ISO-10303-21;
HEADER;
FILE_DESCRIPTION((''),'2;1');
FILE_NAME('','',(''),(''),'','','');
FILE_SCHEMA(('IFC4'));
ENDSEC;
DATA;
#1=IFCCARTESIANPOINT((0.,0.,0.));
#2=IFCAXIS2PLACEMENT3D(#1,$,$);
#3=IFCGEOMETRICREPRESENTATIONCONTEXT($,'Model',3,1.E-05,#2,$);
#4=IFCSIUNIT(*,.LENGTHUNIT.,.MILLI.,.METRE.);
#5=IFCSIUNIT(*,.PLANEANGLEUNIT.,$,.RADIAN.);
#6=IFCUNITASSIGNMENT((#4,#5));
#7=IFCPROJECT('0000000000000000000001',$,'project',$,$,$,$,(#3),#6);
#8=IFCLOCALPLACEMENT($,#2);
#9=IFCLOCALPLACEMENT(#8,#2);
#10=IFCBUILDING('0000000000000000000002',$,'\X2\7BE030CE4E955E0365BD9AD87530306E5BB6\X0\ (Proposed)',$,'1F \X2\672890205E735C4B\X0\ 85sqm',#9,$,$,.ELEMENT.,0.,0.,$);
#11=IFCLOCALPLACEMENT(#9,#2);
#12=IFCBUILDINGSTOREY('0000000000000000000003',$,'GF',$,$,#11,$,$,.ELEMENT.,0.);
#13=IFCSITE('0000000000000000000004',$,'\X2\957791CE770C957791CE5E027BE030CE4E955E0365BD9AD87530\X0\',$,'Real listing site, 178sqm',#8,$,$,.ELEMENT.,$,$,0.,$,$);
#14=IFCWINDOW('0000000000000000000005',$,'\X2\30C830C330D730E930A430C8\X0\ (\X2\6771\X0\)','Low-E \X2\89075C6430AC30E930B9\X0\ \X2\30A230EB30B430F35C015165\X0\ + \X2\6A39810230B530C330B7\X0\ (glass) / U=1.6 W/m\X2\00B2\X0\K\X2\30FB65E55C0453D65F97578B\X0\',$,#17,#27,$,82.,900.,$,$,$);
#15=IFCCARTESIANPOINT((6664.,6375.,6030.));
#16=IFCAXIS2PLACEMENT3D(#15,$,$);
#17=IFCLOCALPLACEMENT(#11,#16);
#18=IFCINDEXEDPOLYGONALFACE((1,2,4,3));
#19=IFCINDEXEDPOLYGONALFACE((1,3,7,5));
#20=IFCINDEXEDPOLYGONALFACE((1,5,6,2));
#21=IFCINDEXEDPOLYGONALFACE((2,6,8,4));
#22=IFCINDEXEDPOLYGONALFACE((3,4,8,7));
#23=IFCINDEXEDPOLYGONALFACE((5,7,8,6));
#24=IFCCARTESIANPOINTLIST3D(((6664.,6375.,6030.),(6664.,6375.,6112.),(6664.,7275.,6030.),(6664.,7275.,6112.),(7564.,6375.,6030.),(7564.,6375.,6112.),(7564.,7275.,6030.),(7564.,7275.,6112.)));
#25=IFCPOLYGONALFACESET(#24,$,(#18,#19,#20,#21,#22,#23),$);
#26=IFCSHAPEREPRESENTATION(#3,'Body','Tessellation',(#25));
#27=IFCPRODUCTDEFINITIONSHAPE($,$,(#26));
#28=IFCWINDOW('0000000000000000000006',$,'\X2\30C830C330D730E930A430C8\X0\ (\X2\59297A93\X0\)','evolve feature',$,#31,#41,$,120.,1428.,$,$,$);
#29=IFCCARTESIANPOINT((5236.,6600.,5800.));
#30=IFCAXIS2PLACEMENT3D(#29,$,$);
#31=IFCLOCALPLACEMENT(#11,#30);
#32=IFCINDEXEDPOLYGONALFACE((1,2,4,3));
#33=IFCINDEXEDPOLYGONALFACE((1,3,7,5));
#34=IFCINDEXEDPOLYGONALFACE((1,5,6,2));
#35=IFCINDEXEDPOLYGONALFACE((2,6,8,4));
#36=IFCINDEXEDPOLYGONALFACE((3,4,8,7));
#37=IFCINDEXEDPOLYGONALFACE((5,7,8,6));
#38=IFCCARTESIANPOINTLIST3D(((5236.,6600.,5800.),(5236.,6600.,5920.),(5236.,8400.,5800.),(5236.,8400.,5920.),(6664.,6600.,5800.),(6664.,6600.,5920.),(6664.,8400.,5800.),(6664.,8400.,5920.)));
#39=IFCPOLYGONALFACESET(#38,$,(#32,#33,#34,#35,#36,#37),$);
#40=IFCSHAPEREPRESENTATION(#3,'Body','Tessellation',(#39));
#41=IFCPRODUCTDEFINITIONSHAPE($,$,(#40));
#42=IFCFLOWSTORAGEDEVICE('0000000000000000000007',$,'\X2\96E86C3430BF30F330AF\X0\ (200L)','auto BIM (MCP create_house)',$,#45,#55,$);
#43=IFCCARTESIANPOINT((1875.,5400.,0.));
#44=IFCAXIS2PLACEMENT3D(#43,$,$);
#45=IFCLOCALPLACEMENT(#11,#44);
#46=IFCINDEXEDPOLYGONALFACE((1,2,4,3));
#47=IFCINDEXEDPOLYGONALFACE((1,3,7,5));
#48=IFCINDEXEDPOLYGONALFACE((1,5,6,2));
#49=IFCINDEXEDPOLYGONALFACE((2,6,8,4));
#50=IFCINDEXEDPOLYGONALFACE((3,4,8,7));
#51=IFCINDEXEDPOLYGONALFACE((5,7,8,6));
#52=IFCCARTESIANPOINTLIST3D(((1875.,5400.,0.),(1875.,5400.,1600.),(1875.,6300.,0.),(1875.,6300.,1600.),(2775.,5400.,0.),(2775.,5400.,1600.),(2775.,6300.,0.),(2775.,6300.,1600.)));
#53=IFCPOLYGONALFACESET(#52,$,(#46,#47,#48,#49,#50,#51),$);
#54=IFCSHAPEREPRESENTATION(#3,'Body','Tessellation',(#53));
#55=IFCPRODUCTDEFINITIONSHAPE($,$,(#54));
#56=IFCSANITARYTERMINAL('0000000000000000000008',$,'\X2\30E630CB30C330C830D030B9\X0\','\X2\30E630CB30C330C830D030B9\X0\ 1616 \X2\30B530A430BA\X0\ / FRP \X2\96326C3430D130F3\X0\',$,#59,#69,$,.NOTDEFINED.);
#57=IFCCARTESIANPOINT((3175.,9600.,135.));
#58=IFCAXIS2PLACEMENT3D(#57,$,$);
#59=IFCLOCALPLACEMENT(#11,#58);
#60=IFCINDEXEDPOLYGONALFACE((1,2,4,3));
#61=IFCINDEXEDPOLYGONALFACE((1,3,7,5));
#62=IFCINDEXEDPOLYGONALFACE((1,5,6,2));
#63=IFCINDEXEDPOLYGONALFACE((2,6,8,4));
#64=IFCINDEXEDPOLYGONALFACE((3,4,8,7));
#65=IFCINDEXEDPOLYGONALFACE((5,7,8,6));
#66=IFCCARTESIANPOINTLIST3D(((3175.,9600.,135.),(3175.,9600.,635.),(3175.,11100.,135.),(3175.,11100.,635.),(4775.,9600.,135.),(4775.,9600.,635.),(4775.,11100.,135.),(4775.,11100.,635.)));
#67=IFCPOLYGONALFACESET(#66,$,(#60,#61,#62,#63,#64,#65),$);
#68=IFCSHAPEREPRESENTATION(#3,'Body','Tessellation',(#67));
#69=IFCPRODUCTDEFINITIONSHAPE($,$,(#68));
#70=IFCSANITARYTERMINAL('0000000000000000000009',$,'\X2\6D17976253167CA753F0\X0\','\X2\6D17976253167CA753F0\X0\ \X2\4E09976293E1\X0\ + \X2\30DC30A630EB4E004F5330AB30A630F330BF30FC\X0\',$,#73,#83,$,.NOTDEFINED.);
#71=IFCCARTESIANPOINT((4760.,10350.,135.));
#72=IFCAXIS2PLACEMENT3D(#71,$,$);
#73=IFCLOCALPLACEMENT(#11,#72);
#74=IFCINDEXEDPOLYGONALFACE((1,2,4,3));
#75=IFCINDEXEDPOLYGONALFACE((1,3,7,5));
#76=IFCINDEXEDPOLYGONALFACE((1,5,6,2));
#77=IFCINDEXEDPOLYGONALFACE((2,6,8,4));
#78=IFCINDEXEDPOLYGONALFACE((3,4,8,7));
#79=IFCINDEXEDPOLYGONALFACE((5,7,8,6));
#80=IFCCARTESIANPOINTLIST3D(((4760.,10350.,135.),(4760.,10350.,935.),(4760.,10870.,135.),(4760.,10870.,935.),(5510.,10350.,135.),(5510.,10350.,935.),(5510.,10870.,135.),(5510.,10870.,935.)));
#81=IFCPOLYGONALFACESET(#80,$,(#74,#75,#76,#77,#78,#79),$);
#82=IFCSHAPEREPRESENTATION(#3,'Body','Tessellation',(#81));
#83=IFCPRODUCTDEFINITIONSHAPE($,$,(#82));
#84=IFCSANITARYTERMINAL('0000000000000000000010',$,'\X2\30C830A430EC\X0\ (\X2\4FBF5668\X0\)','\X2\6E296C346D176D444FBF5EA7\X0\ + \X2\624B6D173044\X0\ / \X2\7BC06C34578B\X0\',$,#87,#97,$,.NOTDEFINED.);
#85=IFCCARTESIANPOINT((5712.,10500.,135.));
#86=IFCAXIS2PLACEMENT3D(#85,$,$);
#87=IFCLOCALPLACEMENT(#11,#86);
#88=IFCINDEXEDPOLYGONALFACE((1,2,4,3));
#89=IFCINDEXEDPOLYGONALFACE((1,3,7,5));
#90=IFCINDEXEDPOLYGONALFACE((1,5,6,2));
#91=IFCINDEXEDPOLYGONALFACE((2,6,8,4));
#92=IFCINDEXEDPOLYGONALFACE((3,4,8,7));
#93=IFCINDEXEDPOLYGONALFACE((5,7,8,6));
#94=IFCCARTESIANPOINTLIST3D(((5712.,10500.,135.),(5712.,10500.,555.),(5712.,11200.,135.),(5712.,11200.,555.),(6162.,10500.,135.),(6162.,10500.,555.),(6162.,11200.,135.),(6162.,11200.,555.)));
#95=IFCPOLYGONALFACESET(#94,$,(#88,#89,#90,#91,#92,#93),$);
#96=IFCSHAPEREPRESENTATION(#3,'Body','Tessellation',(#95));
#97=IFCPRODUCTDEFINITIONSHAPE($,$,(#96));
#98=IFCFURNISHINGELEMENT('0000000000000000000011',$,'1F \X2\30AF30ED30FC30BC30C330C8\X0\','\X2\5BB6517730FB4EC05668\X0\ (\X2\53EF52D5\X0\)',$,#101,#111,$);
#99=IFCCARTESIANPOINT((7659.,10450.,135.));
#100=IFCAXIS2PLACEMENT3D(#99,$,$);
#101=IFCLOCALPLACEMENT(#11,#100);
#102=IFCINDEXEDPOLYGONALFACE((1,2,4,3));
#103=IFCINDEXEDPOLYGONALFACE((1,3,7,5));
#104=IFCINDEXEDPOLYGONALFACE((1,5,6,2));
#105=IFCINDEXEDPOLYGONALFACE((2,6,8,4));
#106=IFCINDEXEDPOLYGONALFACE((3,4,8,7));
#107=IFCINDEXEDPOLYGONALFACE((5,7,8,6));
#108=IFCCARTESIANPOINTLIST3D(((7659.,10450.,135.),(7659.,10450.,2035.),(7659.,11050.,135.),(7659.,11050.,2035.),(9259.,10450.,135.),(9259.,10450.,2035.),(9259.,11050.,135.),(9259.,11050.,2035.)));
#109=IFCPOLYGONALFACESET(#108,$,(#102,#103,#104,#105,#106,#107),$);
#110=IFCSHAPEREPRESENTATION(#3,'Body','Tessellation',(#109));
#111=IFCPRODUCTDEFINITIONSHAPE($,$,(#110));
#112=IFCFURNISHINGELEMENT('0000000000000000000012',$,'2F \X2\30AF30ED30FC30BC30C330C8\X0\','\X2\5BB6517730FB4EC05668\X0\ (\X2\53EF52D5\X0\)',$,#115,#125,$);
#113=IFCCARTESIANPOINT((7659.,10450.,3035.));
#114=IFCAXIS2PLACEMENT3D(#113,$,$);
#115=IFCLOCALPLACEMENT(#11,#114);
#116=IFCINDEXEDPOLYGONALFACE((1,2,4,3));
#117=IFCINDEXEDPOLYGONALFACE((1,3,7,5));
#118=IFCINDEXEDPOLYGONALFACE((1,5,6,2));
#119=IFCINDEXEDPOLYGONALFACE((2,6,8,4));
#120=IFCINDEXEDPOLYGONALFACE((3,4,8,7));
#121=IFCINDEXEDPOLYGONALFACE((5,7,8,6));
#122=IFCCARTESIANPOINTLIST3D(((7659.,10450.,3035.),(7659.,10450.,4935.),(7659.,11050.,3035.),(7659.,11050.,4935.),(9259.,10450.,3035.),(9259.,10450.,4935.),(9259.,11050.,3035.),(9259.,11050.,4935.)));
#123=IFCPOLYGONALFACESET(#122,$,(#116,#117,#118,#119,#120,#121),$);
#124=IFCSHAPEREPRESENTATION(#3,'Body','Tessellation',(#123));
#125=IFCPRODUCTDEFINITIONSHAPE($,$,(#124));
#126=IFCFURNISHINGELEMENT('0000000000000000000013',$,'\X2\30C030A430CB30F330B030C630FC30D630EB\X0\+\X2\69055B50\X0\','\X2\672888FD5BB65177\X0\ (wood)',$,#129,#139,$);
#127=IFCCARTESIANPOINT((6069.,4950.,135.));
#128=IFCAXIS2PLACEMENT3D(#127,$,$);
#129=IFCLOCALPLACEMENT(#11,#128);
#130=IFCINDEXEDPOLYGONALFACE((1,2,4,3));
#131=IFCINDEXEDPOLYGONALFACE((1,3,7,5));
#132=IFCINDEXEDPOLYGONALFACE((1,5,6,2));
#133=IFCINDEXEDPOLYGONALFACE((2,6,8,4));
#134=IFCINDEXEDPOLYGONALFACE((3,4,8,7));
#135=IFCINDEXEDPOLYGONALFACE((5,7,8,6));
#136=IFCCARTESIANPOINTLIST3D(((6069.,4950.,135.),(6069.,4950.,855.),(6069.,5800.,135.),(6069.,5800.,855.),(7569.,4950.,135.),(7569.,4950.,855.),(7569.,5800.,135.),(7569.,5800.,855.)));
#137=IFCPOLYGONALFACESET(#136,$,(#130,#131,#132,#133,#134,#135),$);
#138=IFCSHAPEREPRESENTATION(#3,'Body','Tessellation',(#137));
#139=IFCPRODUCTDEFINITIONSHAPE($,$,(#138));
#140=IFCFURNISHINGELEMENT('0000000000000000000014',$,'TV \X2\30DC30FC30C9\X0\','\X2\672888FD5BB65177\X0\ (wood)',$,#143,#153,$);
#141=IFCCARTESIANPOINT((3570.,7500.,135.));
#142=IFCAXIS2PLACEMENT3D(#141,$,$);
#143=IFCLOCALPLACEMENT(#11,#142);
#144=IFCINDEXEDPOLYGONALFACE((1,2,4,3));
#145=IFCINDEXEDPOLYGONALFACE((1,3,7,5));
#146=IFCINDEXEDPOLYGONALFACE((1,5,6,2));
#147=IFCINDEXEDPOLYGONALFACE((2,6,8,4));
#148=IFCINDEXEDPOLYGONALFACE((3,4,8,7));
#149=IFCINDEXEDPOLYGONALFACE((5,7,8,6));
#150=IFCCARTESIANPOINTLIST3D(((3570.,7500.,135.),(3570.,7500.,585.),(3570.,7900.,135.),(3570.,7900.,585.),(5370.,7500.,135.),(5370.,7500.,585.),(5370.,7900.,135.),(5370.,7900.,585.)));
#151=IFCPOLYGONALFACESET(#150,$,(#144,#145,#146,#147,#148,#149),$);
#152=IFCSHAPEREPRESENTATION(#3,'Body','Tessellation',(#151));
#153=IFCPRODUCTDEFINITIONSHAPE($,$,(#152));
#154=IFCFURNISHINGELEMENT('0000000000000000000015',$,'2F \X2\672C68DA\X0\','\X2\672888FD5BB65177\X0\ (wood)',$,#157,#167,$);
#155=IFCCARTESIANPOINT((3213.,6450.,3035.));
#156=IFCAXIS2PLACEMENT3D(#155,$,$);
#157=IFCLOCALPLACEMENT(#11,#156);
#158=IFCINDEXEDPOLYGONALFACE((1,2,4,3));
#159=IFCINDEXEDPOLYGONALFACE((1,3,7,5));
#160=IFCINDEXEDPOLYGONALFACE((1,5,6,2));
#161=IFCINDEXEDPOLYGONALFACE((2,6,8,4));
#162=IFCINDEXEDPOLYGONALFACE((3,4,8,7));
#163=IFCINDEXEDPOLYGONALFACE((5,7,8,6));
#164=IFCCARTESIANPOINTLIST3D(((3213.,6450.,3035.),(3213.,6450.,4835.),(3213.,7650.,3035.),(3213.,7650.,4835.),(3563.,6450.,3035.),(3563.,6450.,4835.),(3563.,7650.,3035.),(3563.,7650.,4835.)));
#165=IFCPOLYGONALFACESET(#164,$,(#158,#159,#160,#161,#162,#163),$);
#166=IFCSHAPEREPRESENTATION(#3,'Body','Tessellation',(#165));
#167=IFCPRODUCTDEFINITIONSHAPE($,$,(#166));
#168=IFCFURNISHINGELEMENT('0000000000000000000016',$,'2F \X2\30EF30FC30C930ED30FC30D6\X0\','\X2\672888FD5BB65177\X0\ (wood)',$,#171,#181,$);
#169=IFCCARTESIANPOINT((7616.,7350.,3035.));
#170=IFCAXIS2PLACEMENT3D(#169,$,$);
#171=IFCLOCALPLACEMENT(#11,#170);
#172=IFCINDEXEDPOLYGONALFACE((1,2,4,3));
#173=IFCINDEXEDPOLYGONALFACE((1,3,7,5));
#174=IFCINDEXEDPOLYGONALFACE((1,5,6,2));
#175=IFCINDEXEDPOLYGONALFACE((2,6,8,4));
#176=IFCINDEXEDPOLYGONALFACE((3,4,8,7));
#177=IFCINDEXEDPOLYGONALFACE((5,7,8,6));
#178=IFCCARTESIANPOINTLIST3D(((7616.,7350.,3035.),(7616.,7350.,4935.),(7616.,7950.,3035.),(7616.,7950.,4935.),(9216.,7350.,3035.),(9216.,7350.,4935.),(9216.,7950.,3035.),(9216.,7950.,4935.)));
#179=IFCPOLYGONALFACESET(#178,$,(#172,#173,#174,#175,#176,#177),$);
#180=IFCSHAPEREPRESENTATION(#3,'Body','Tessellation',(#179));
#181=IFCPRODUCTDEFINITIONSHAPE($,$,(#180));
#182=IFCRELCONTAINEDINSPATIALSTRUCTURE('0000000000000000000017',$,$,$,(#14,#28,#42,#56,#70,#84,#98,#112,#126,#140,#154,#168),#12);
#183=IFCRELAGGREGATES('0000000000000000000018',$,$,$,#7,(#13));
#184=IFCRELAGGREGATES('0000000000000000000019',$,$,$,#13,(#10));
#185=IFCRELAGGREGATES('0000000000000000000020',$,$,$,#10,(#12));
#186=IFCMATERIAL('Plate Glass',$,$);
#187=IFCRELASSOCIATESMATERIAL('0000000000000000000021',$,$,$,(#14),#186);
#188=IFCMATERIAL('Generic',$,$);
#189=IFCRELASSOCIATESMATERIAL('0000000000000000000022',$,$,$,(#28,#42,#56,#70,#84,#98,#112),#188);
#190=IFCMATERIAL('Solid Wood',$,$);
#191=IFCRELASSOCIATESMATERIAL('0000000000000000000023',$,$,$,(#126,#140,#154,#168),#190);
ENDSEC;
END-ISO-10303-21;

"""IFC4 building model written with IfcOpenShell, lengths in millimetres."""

from ifc_helpers import new_model, si_unit, frame, frame_2d, origin, place, context, project, spatial, rectangle, extrude, material, element, save


model = new_model("IFC4")

# Units and contexts
model_context = context("Model", 3, precision=1e-05, world=origin())
ifc_project = project(units=[si_unit("LENGTHUNIT", "METRE", prefix="MILLI"), si_unit("PLANEANGLEUNIT", "RADIAN")], contexts=[model_context])

# Site, building, storey
site_placement = place(None, origin())
site = spatial("IfcSite", under=ifc_project, at=site_placement, Name="長野県長野市篠ノ井布施高田", ObjectType="Real listing site, 178sqm", CompositionType="ELEMENT", RefElevation=0.0)
building_placement = place(site_placement, origin())
building = spatial("IfcBuilding", under=site, at=building_placement, Name="篠ノ井布施高田の家 (Proposed)", ObjectType="1F 木造平屋 85sqm", CompositionType="ELEMENT", ElevationOfRefHeight=0.0, ElevationOfTerrain=0.0)
storey_placement = place(building_placement, origin())
storey = spatial("IfcBuildingStorey", under=building, at=storey_placement, Name="GF", CompositionType="ELEMENT", Elevation=0.0)

# Shared definitions
ifc_material_1 = material(Name="Solid Wood")
ifc_material_2 = material(Name="Plate Glass")

# Windows
window_1_placement = place(storey_placement, frame((6664.0, 6375.0, 6030.0)))
element("IfcWindow", 1, at=window_1_placement, inside=storey, material=ifc_material_2, Name="トップライト (東)", Description="Low-E 複層ガラス アルゴン封入 + 樹脂サッシ (glass) / U=1.6 W/m²K・日射取得型", OverallHeight=82.0, OverallWidth=900.0, context=model_context, shape_type="SweptSolid", body=[
    extrude(rectangle(XDim=900.0, YDim=900.0, at=frame_2d((450.0, 450.0))), frame((6664.0, 6375.0, 6030.0)), (0.0, 0.0, 1.0), 82.0),
])
ifc_material_3 = material(Name="Generic")
window_2_placement = place(storey_placement, frame((5236.0, 6600.0, 5800.0)))
element("IfcWindow", 2, at=window_2_placement, inside=storey, material=ifc_material_3, Name="トップライト (天窓)", Description="evolve feature", OverallHeight=120.0, OverallWidth=1428.0, context=model_context, shape_type="SweptSolid", body=[
    extrude(rectangle(XDim=1428.0, YDim=1800.0, at=frame_2d((714.0, 900.0))), frame((5236.0, 6600.0, 5800.0)), (0.0, 0.0, 1.0), 120.0),
])

# Flow storage device
flow_storage_device_placement = place(storey_placement, frame((1875.0, 5400.0, 0.0)))
element("IfcFlowStorageDevice", 3, at=flow_storage_device_placement, inside=storey, material=ifc_material_3, Name="雨水タンク (200L)", Description="auto BIM (MCP create_house)", context=model_context, shape_type="SweptSolid", body=[
    extrude(rectangle(XDim=900.0, YDim=900.0, at=frame_2d((450.0, 450.0))), frame((1875.0, 5400.0, 0.0)), (0.0, 0.0, 1.0), 1600.0),
])

# Sanitary terminals
sanitary_terminal_1_placement = place(storey_placement, frame((3175.0, 9600.0, 135.0)))
element("IfcSanitaryTerminal", 4, at=sanitary_terminal_1_placement, inside=storey, material=ifc_material_3, Name="ユニットバス", Description="ユニットバス 1616 サイズ / FRP 防水パン", PredefinedType="NOTDEFINED", context=model_context, shape_type="SweptSolid", body=[
    extrude(rectangle(XDim=1600.0, YDim=1500.0, at=frame_2d((800.0, 750.0))), frame((3175.0, 9600.0, 135.0)), (0.0, 0.0, 1.0), 500.0),
])
sanitary_terminal_2_placement = place(storey_placement, frame((4760.0, 10350.0, 135.0)))
element("IfcSanitaryTerminal", 5, at=sanitary_terminal_2_placement, inside=storey, material=ifc_material_3, Name="洗面化粧台", Description="洗面化粧台 三面鏡 + ボウル一体カウンター", PredefinedType="NOTDEFINED", context=model_context, shape_type="SweptSolid", body=[
    extrude(rectangle(XDim=750.0, YDim=520.0, at=frame_2d((375.0, 260.0))), frame((4760.0, 10350.0, 135.0)), (0.0, 0.0, 1.0), 800.0),
])
sanitary_terminal_3_placement = place(storey_placement, frame((5712.0, 10500.0, 135.0)))
element("IfcSanitaryTerminal", 6, at=sanitary_terminal_3_placement, inside=storey, material=ifc_material_3, Name="トイレ (便器)", Description="温水洗浄便座 + 手洗い / 節水型", PredefinedType="NOTDEFINED", context=model_context, shape_type="SweptSolid", body=[
    extrude(rectangle(XDim=450.0, YDim=700.0, at=frame_2d((225.0, 350.0))), frame((5712.0, 10500.0, 135.0)), (0.0, 0.0, 1.0), 420.0),
])

# Furnishing elements
furnishing_1_placement = place(storey_placement, frame((7659.0, 10450.0, 135.0)))
element("IfcFurnishingElement", 7, at=furnishing_1_placement, inside=storey, material=ifc_material_3, Name="1F クローゼット", Description="家具・什器 (可動)", context=model_context, shape_type="SweptSolid", body=[
    extrude(rectangle(XDim=1600.0, YDim=600.0, at=frame_2d((800.0, 300.0))), frame((7659.0, 10450.0, 135.0)), (0.0, 0.0, 1.0), 1900.0),
])
furnishing_2_placement = place(storey_placement, frame((7659.0, 10450.0, 3035.0)))
element("IfcFurnishingElement", 8, at=furnishing_2_placement, inside=storey, material=ifc_material_3, Name="2F クローゼット", Description="家具・什器 (可動)", context=model_context, shape_type="SweptSolid", body=[
    extrude(rectangle(XDim=1600.0, YDim=600.0, at=frame_2d((800.0, 300.0))), frame((7659.0, 10450.0, 3035.0)), (0.0, 0.0, 1.0), 1900.0),
])
furnishing_3_placement = place(storey_placement, frame((6069.0, 4950.0, 135.0)))
element("IfcFurnishingElement", 9, at=furnishing_3_placement, inside=storey, material=ifc_material_1, Name="ダイニングテーブル+椅子", Description="木製家具 (wood)", context=model_context, shape_type="SweptSolid", body=[
    extrude(rectangle(XDim=1500.0, YDim=850.0, at=frame_2d((750.0, 425.0))), frame((6069.0, 4950.0, 135.0)), (0.0, 0.0, 1.0), 720.0),
])
furnishing_4_placement = place(storey_placement, frame((3570.0, 7500.0, 135.0)))
element("IfcFurnishingElement", 10, at=furnishing_4_placement, inside=storey, material=ifc_material_1, Name="TV ボード", Description="木製家具 (wood)", context=model_context, shape_type="SweptSolid", body=[
    extrude(rectangle(XDim=1800.0, YDim=400.0, at=frame_2d((900.0, 200.0))), frame((3570.0, 7500.0, 135.0)), (0.0, 0.0, 1.0), 450.0),
])
furnishing_5_placement = place(storey_placement, frame((3213.0, 6450.0, 3035.0)))
element("IfcFurnishingElement", 11, at=furnishing_5_placement, inside=storey, material=ifc_material_1, Name="2F 本棚", Description="木製家具 (wood)", context=model_context, shape_type="SweptSolid", body=[
    extrude(rectangle(XDim=350.0, YDim=1200.0, at=frame_2d((175.0, 600.0))), frame((3213.0, 6450.0, 3035.0)), (0.0, 0.0, 1.0), 1800.0),
])
furnishing_6_placement = place(storey_placement, frame((7616.0, 7350.0, 3035.0)))
element("IfcFurnishingElement", 12, at=furnishing_6_placement, inside=storey, material=ifc_material_1, Name="2F ワードローブ", Description="木製家具 (wood)", context=model_context, shape_type="SweptSolid", body=[
    extrude(rectangle(XDim=1600.0, YDim=600.0, at=frame_2d((800.0, 300.0))), frame((7616.0, 7350.0, 3035.0)), (0.0, 0.0, 1.0), 1900.0),
])

save(model, "model.ifc")
